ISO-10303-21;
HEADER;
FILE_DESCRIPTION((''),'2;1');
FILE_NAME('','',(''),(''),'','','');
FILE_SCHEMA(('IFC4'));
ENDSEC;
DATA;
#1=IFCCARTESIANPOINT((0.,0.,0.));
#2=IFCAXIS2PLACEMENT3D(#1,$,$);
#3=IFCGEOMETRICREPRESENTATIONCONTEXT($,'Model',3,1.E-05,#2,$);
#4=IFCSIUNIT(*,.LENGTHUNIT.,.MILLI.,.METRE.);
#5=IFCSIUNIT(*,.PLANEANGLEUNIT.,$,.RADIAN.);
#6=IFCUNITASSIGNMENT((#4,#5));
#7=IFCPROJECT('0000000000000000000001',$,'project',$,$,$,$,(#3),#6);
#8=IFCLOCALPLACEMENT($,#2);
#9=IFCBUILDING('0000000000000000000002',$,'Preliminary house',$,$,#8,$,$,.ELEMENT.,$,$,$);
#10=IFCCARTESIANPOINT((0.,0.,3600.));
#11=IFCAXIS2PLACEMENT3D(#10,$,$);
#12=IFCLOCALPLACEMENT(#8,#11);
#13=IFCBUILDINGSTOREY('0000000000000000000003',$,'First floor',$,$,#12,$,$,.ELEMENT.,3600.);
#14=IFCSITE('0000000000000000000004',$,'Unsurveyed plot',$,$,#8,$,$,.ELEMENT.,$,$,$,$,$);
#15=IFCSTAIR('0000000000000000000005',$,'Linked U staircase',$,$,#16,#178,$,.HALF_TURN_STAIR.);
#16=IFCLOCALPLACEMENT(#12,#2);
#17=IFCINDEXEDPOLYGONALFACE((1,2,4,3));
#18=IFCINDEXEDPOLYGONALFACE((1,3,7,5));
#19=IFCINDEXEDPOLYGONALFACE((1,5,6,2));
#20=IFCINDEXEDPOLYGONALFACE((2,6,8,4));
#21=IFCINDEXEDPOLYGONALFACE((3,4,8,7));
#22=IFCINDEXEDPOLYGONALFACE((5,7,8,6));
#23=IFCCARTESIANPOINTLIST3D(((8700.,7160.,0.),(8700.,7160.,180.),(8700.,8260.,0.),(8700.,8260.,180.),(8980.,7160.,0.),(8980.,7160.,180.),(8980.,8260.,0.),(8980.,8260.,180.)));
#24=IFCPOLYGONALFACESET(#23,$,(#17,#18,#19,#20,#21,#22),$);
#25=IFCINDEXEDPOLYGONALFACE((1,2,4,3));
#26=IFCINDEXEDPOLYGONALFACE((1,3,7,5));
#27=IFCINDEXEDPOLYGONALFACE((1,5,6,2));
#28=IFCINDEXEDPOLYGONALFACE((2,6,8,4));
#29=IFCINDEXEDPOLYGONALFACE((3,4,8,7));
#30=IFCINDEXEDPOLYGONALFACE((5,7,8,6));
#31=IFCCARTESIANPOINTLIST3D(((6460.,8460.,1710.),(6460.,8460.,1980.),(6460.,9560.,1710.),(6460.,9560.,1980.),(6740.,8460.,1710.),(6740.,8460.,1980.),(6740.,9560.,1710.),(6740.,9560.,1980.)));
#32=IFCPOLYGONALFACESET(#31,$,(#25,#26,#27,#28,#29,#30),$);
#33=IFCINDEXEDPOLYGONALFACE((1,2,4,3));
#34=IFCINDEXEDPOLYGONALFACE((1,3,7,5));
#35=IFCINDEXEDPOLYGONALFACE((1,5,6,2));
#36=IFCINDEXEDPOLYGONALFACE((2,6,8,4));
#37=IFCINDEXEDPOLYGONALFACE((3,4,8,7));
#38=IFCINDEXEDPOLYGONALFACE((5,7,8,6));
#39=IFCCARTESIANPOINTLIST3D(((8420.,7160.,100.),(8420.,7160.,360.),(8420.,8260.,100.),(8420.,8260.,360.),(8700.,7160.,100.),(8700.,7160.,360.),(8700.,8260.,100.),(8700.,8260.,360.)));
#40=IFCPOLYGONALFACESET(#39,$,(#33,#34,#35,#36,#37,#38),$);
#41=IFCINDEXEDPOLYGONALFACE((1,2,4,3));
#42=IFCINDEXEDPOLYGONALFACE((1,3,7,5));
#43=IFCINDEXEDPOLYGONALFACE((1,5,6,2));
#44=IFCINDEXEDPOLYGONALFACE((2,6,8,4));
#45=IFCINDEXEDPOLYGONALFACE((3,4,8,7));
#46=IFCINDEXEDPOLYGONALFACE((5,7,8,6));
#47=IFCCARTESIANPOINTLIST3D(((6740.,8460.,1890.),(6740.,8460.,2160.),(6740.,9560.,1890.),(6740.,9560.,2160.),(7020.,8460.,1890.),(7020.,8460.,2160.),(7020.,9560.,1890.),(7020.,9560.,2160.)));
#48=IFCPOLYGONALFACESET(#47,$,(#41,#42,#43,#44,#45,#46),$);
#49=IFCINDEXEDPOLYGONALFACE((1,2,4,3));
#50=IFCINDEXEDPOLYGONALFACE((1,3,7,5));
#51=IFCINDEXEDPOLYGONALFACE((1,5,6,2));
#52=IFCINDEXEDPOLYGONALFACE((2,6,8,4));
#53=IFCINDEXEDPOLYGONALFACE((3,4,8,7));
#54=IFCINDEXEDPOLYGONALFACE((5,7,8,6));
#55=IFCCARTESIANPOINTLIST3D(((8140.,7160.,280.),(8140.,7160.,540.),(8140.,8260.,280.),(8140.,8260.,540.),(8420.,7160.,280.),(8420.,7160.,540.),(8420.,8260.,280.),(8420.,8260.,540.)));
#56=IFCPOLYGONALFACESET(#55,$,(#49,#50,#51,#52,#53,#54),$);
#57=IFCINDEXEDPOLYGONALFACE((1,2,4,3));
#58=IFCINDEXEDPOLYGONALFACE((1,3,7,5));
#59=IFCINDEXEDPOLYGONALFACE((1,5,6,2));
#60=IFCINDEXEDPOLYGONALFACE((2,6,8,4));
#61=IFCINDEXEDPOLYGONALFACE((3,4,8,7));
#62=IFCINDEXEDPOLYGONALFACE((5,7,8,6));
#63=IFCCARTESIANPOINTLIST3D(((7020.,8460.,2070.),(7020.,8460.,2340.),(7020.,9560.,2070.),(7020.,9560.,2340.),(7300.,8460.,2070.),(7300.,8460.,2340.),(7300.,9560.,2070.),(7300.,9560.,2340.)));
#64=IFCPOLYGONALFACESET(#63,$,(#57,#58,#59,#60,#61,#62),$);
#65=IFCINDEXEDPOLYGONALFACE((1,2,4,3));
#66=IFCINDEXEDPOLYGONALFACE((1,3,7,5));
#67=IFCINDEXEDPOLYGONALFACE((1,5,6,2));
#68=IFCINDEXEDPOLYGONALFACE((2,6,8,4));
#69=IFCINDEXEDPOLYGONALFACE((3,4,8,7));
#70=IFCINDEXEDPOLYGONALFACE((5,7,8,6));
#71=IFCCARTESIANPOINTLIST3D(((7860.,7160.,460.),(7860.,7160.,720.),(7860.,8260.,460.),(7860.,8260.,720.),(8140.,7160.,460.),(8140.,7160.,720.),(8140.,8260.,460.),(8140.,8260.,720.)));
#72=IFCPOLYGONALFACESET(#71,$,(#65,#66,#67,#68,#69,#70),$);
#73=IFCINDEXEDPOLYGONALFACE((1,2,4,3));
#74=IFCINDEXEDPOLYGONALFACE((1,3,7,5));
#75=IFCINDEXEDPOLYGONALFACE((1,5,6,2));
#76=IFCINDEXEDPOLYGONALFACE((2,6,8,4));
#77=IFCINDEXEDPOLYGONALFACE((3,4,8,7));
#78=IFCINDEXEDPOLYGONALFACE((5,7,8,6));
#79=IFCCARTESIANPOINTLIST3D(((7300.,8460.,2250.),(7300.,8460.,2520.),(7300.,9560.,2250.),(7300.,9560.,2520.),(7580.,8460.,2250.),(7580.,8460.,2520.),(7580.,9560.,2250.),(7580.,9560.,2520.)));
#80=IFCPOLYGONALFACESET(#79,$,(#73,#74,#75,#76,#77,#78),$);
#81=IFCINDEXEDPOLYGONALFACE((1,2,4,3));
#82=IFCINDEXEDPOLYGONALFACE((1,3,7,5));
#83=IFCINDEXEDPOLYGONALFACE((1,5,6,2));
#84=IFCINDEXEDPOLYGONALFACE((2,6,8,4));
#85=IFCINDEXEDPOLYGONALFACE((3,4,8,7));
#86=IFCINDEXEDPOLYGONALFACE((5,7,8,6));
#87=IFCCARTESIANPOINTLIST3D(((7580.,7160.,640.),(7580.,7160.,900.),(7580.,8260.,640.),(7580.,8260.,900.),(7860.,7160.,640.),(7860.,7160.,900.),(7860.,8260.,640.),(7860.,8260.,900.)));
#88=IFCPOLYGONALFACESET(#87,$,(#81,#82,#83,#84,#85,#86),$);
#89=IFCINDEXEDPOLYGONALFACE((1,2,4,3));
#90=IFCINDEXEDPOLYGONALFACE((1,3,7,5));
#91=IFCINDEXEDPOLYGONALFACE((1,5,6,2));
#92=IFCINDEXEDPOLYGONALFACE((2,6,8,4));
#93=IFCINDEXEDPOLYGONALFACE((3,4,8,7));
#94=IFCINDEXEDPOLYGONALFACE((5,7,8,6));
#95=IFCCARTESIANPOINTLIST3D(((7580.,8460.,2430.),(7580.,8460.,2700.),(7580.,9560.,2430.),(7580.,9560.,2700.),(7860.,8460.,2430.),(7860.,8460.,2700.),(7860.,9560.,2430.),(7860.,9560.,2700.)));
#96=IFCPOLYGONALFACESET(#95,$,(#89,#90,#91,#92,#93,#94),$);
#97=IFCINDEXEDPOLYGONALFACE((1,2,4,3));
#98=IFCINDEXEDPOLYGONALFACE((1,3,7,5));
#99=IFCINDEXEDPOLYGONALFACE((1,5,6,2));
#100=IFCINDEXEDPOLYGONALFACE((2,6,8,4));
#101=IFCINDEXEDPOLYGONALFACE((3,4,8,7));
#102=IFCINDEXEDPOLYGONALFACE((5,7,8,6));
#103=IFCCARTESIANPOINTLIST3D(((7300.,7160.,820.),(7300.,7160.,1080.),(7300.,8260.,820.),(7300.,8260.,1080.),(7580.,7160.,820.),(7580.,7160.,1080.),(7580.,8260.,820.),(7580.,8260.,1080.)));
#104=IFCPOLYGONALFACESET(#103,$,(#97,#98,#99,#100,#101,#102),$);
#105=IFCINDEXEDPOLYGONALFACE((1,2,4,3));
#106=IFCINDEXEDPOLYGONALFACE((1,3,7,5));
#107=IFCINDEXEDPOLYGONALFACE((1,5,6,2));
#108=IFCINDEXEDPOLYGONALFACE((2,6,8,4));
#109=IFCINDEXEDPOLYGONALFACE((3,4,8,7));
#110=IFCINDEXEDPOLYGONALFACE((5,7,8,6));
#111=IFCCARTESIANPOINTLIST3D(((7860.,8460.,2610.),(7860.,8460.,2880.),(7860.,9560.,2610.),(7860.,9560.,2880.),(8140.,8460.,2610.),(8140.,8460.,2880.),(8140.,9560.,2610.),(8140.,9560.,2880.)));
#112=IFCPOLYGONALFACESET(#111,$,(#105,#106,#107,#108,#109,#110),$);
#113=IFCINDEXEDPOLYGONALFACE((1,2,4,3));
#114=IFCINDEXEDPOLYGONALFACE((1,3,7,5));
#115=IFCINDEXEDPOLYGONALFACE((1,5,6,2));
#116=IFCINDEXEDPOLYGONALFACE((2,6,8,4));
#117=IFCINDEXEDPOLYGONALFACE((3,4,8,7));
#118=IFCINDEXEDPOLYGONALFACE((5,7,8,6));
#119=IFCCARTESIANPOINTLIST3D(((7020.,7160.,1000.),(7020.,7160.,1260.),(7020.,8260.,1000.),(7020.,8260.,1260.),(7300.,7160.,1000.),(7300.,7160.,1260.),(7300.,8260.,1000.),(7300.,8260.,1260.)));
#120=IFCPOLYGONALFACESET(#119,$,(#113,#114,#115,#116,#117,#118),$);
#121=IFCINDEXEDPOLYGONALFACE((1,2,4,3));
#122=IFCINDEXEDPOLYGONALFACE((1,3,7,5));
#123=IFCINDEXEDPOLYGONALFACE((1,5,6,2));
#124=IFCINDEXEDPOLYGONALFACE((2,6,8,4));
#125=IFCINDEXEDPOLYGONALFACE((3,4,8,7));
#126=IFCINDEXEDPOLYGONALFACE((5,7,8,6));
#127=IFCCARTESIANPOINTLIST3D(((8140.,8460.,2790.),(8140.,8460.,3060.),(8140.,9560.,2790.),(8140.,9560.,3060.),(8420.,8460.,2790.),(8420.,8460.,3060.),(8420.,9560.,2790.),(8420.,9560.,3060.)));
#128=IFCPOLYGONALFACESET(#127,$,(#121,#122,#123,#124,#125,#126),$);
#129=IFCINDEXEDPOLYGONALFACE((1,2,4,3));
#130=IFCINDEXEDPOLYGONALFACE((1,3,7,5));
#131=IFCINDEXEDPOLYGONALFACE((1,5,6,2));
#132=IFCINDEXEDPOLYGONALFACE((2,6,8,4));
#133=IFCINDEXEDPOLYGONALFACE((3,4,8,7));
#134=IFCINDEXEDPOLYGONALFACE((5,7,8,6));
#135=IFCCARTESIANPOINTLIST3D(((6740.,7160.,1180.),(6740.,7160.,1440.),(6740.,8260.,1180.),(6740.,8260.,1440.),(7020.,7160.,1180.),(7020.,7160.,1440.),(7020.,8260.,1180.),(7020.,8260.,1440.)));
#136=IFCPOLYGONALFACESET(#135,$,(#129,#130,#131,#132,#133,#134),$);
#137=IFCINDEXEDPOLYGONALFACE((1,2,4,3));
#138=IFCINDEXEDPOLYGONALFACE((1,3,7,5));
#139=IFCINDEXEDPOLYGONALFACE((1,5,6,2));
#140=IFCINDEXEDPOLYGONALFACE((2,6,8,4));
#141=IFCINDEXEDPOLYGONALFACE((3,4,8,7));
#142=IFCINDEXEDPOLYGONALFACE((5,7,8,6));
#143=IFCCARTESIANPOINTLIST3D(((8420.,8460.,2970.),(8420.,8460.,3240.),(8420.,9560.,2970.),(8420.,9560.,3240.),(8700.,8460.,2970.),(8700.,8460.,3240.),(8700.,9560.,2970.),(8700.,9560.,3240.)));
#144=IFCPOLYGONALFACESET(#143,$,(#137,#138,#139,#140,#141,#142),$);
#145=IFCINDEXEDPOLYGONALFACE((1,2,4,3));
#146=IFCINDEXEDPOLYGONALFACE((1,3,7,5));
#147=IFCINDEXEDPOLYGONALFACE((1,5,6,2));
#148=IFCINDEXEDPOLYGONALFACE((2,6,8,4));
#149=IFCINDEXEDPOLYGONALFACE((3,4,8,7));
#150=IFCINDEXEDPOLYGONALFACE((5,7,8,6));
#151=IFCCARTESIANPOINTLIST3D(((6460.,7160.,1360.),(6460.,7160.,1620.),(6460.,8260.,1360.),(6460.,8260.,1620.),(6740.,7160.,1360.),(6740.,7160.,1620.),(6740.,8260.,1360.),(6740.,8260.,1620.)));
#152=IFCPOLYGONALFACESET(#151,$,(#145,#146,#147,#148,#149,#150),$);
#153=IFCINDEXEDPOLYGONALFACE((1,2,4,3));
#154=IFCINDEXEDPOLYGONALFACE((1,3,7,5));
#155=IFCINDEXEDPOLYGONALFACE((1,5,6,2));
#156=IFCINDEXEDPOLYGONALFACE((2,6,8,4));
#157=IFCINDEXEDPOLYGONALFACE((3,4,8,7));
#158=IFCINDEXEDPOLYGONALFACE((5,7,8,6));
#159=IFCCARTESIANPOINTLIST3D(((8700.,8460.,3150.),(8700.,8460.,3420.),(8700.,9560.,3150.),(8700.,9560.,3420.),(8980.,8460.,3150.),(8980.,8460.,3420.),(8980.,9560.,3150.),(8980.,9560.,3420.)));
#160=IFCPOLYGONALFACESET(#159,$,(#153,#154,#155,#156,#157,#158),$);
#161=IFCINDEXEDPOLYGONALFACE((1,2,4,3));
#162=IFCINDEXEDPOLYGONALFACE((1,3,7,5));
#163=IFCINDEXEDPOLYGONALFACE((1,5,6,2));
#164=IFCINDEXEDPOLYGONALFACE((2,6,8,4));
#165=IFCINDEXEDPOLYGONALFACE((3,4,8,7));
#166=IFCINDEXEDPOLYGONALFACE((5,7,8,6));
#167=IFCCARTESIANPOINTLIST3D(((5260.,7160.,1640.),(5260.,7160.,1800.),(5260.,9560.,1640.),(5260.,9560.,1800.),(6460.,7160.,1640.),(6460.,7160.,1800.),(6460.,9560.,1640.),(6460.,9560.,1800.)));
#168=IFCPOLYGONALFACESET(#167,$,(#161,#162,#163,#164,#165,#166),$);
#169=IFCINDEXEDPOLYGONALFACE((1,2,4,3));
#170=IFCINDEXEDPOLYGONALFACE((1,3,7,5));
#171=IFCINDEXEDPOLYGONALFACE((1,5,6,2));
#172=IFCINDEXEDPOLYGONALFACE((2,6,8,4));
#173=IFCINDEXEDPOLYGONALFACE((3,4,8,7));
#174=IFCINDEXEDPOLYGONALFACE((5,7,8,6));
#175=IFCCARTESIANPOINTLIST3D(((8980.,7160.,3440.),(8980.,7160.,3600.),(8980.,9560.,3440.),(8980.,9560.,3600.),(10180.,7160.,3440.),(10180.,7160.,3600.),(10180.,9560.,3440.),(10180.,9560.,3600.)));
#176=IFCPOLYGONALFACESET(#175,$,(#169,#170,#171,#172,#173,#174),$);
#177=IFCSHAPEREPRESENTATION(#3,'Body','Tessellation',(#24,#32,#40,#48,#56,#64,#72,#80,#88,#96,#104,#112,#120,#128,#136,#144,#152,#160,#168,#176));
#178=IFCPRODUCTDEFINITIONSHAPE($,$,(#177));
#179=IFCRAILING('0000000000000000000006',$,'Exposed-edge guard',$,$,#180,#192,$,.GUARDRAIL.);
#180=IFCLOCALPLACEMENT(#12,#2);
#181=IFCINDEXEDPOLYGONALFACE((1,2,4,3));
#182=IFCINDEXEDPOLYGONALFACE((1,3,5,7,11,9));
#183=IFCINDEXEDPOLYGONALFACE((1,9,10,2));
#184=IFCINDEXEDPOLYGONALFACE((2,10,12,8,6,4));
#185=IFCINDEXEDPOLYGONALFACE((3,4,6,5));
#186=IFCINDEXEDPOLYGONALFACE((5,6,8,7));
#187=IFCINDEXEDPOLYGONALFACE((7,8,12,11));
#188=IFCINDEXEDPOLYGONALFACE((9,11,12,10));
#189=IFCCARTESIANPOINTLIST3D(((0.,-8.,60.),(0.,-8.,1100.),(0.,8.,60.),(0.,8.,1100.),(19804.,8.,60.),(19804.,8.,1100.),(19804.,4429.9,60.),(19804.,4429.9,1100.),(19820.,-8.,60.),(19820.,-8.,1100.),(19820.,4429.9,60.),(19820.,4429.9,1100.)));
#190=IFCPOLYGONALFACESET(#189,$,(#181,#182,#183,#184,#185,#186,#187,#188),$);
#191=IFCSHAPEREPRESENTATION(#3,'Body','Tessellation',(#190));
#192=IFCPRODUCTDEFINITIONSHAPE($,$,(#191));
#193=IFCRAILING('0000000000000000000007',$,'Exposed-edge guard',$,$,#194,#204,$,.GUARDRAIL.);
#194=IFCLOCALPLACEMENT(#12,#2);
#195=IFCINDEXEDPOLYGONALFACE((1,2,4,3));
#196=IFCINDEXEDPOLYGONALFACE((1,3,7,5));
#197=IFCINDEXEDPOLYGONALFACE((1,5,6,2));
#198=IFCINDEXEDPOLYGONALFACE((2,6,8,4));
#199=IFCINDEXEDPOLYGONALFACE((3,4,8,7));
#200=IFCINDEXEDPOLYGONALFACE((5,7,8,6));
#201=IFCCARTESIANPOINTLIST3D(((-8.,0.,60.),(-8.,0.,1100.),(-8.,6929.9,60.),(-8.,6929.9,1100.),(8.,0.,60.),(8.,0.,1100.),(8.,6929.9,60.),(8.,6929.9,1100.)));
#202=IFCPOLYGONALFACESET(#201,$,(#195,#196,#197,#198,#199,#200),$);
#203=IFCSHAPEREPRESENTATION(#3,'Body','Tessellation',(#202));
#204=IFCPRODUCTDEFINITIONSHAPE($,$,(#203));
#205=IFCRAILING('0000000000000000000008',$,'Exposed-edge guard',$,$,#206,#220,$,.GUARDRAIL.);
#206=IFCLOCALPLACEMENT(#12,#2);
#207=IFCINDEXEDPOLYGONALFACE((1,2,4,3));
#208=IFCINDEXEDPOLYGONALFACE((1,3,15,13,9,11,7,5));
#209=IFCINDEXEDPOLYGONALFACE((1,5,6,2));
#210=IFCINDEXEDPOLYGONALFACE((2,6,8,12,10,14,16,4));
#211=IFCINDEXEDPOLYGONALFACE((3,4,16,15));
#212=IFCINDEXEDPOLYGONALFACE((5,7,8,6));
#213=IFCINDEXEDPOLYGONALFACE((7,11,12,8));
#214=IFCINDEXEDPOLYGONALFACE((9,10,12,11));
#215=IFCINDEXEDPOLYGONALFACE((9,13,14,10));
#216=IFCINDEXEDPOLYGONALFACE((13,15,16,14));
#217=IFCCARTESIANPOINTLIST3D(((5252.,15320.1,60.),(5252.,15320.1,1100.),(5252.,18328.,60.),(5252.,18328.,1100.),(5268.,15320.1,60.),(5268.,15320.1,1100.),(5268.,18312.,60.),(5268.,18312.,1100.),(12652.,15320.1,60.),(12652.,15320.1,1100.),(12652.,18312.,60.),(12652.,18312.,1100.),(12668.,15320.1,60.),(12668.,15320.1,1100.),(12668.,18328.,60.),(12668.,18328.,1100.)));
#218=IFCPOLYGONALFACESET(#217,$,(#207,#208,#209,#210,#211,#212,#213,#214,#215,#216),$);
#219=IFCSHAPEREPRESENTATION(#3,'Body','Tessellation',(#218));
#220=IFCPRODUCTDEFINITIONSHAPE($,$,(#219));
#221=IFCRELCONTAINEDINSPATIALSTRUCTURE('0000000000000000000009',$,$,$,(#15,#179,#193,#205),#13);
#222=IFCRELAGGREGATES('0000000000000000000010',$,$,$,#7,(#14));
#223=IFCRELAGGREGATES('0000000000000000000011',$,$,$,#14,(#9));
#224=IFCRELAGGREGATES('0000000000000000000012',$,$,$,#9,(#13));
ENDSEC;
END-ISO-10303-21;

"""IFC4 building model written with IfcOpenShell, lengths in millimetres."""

from ifc_helpers import new_model, si_unit, frame, origin, place, context, project, spatial, polyline, outline, extrude, element, save


model = new_model("IFC4")

# Units and contexts
model_context = context("Model", 3, precision=1e-05, world=origin())
ifc_project = project(units=[si_unit("LENGTHUNIT", "METRE", prefix="MILLI"), si_unit("PLANEANGLEUNIT", "RADIAN")], contexts=[model_context])

# Site, building, storey
placement_1 = place(None, origin())
site = spatial("IfcSite", under=ifc_project, at=placement_1, Name="Unsurveyed plot", CompositionType="ELEMENT")
building = spatial("IfcBuilding", under=site, at=placement_1, Name="Preliminary house", CompositionType="ELEMENT")
placement_2 = place(placement_1, frame((0.0, 0.0, 3600.0)))
storey = spatial("IfcBuildingStorey", under=building, at=placement_2, Name="First floor", CompositionType="ELEMENT", Elevation=3600.0)

# Stair
element("IfcStair", 1, at=placement_2, inside=storey, Name="Linked U staircase", PredefinedType="HALF_TURN_STAIR", context=model_context, shape_type="SweptSolid", body=[
    extrude(outline(polyline([(8980.0, 8260.0), (8700.0, 8260.0), (8700.0, 7160.0), (8980.0, 7160.0), (8980.0, 8260.0)])), origin(), (0.0, 0.0, 1.0), 180.0),
    extrude(outline(polyline([(6740.0, 9560.0), (6460.0, 9560.0), (6460.0, 8460.0), (6740.0, 8460.0), (6740.0, 9560.0)])), frame((0.0, 0.0, 1710.0)), (0.0, 0.0, 1.0), 270.0),
    extrude(outline(polyline([(8700.0, 8260.0), (8420.0, 8260.0), (8420.0, 7160.0), (8700.0, 7160.0), (8700.0, 8260.0)])), frame((0.0, 0.0, 100.0)), (0.0, 0.0, 1.0), 260.0),
    extrude(outline(polyline([(7020.0, 9560.0), (6740.0, 9560.0), (6740.0, 8460.0), (7020.0, 8460.0), (7020.0, 9560.0)])), frame((0.0, 0.0, 1890.0)), (0.0, 0.0, 1.0), 270.0),
    extrude(outline(polyline([(8420.0, 8260.0), (8140.0, 8260.0), (8140.0, 7160.0), (8420.0, 7160.0), (8420.0, 8260.0)])), frame((0.0, 0.0, 280.0)), (0.0, 0.0, 1.0), 260.0),
    extrude(outline(polyline([(7300.0, 9560.0), (7020.0, 9560.0), (7020.0, 8460.0), (7300.0, 8460.0), (7300.0, 9560.0)])), frame((0.0, 0.0, 2070.0)), (0.0, 0.0, 1.0), 270.0),
    extrude(outline(polyline([(8140.0, 8260.0), (7860.0, 8260.0), (7860.0, 7160.0), (8140.0, 7160.0), (8140.0, 8260.0)])), frame((0.0, 0.0, 460.0)), (0.0, 0.0, 1.0), 260.0),
    extrude(outline(polyline([(7580.0, 9560.0), (7300.0, 9560.0), (7300.0, 8460.0), (7580.0, 8460.0), (7580.0, 9560.0)])), frame((0.0, 0.0, 2250.0)), (0.0, 0.0, 1.0), 270.0),
    extrude(outline(polyline([(7860.0, 8260.0), (7580.0, 8260.0), (7580.0, 7160.0), (7860.0, 7160.0), (7860.0, 8260.0)])), frame((0.0, 0.0, 640.0)), (0.0, 0.0, 1.0), 260.0),
    extrude(outline(polyline([(7860.0, 9560.0), (7580.0, 9560.0), (7580.0, 8460.0), (7860.0, 8460.0), (7860.0, 9560.0)])), frame((0.0, 0.0, 2430.0)), (0.0, 0.0, 1.0), 270.0),
    extrude(outline(polyline([(7580.0, 8260.0), (7300.0, 8260.0), (7300.0, 7160.0), (7580.0, 7160.0), (7580.0, 8260.0)])), frame((0.0, 0.0, 820.0)), (0.0, 0.0, 1.0), 260.0),
    extrude(outline(polyline([(8140.0, 9560.0), (7860.0, 9560.0), (7860.0, 8460.0), (8140.0, 8460.0), (8140.0, 9560.0)])), frame((0.0, 0.0, 2610.0)), (0.0, 0.0, 1.0), 270.0),
    extrude(outline(polyline([(7300.0, 8260.0), (7020.0, 8260.0), (7020.0, 7160.0), (7300.0, 7160.0), (7300.0, 8260.0)])), frame((0.0, 0.0, 1000.0)), (0.0, 0.0, 1.0), 260.0),
    extrude(outline(polyline([(8420.0, 9560.0), (8140.0, 9560.0), (8140.0, 8460.0), (8420.0, 8460.0), (8420.0, 9560.0)])), frame((0.0, 0.0, 2790.0)), (0.0, 0.0, 1.0), 270.0),
    extrude(outline(polyline([(7020.0, 8260.0), (6740.0, 8260.0), (6740.0, 7160.0), (7020.0, 7160.0), (7020.0, 8260.0)])), frame((0.0, 0.0, 1180.0)), (0.0, 0.0, 1.0), 260.0),
    extrude(outline(polyline([(8700.0, 9560.0), (8420.0, 9560.0), (8420.0, 8460.0), (8700.0, 8460.0), (8700.0, 9560.0)])), frame((0.0, 0.0, 2970.0)), (0.0, 0.0, 1.0), 270.0),
    extrude(outline(polyline([(6740.0, 8260.0), (6460.0, 8260.0), (6460.0, 7160.0), (6740.0, 7160.0), (6740.0, 8260.0)])), frame((0.0, 0.0, 1360.0)), (0.0, 0.0, 1.0), 260.0),
    extrude(outline(polyline([(8980.0, 9560.0), (8700.0, 9560.0), (8700.0, 8460.0), (8980.0, 8460.0), (8980.0, 9560.0)])), frame((0.0, 0.0, 3150.0)), (0.0, 0.0, 1.0), 270.0),
    extrude(outline(polyline([(6460.0, 9560.0), (5260.0, 9560.0), (5260.0, 7160.0), (6460.0, 7160.0), (6460.0, 9560.0)])), frame((0.0, 0.0, 1640.0)), (0.0, 0.0, 1.0), 160.0),
    extrude(outline(polyline([(10180.0, 9560.0), (8980.0, 9560.0), (8980.0, 7160.0), (10180.0, 7160.0), (10180.0, 9560.0)])), frame((0.0, 0.0, 3440.0)), (0.0, 0.0, 1.0), 160.0),
])

# Railings
element("IfcRailing", 2, at=placement_2, inside=storey, Name="Exposed-edge guard", PredefinedType="GUARDRAIL", context=model_context, shape_type="SweptSolid", body=[
    extrude(outline(polyline([(19804.0, 8.0), (19804.0, 4429.9), (19820.0, 4429.9), (19820.0, -8.0), (0.0, -8.0), (0.0, 8.0), (19804.0, 8.0)])), frame((0.0, 0.0, 60.0)), (0.0, 0.0, 1.0), 1040.0),
])
element("IfcRailing", 3, at=placement_2, inside=storey, Name="Exposed-edge guard", PredefinedType="GUARDRAIL", context=model_context, shape_type="SweptSolid", body=[
    extrude(outline(polyline([(8.0, 0.0), (-8.0, 0.0), (-8.0, 6929.9), (8.0, 6929.9), (8.0, 0.0)])), frame((0.0, 0.0, 60.0)), (0.0, 0.0, 1.0), 1040.0),
])
element("IfcRailing", 4, at=placement_2, inside=storey, Name="Exposed-edge guard", PredefinedType="GUARDRAIL", context=model_context, shape_type="SweptSolid", body=[
    extrude(outline(polyline([(12652.0, 18312.0), (5268.0, 18312.0), (5268.0, 15320.1), (5252.0, 15320.1), (5252.0, 18328.0), (12668.0, 18328.0), (12668.0, 15320.1), (12652.0, 15320.1), (12652.0, 18312.0)])), frame((0.0, 0.0, 60.0)), (0.0, 0.0, 1.0), 1040.0),
])

save(model, "model.ifc")
